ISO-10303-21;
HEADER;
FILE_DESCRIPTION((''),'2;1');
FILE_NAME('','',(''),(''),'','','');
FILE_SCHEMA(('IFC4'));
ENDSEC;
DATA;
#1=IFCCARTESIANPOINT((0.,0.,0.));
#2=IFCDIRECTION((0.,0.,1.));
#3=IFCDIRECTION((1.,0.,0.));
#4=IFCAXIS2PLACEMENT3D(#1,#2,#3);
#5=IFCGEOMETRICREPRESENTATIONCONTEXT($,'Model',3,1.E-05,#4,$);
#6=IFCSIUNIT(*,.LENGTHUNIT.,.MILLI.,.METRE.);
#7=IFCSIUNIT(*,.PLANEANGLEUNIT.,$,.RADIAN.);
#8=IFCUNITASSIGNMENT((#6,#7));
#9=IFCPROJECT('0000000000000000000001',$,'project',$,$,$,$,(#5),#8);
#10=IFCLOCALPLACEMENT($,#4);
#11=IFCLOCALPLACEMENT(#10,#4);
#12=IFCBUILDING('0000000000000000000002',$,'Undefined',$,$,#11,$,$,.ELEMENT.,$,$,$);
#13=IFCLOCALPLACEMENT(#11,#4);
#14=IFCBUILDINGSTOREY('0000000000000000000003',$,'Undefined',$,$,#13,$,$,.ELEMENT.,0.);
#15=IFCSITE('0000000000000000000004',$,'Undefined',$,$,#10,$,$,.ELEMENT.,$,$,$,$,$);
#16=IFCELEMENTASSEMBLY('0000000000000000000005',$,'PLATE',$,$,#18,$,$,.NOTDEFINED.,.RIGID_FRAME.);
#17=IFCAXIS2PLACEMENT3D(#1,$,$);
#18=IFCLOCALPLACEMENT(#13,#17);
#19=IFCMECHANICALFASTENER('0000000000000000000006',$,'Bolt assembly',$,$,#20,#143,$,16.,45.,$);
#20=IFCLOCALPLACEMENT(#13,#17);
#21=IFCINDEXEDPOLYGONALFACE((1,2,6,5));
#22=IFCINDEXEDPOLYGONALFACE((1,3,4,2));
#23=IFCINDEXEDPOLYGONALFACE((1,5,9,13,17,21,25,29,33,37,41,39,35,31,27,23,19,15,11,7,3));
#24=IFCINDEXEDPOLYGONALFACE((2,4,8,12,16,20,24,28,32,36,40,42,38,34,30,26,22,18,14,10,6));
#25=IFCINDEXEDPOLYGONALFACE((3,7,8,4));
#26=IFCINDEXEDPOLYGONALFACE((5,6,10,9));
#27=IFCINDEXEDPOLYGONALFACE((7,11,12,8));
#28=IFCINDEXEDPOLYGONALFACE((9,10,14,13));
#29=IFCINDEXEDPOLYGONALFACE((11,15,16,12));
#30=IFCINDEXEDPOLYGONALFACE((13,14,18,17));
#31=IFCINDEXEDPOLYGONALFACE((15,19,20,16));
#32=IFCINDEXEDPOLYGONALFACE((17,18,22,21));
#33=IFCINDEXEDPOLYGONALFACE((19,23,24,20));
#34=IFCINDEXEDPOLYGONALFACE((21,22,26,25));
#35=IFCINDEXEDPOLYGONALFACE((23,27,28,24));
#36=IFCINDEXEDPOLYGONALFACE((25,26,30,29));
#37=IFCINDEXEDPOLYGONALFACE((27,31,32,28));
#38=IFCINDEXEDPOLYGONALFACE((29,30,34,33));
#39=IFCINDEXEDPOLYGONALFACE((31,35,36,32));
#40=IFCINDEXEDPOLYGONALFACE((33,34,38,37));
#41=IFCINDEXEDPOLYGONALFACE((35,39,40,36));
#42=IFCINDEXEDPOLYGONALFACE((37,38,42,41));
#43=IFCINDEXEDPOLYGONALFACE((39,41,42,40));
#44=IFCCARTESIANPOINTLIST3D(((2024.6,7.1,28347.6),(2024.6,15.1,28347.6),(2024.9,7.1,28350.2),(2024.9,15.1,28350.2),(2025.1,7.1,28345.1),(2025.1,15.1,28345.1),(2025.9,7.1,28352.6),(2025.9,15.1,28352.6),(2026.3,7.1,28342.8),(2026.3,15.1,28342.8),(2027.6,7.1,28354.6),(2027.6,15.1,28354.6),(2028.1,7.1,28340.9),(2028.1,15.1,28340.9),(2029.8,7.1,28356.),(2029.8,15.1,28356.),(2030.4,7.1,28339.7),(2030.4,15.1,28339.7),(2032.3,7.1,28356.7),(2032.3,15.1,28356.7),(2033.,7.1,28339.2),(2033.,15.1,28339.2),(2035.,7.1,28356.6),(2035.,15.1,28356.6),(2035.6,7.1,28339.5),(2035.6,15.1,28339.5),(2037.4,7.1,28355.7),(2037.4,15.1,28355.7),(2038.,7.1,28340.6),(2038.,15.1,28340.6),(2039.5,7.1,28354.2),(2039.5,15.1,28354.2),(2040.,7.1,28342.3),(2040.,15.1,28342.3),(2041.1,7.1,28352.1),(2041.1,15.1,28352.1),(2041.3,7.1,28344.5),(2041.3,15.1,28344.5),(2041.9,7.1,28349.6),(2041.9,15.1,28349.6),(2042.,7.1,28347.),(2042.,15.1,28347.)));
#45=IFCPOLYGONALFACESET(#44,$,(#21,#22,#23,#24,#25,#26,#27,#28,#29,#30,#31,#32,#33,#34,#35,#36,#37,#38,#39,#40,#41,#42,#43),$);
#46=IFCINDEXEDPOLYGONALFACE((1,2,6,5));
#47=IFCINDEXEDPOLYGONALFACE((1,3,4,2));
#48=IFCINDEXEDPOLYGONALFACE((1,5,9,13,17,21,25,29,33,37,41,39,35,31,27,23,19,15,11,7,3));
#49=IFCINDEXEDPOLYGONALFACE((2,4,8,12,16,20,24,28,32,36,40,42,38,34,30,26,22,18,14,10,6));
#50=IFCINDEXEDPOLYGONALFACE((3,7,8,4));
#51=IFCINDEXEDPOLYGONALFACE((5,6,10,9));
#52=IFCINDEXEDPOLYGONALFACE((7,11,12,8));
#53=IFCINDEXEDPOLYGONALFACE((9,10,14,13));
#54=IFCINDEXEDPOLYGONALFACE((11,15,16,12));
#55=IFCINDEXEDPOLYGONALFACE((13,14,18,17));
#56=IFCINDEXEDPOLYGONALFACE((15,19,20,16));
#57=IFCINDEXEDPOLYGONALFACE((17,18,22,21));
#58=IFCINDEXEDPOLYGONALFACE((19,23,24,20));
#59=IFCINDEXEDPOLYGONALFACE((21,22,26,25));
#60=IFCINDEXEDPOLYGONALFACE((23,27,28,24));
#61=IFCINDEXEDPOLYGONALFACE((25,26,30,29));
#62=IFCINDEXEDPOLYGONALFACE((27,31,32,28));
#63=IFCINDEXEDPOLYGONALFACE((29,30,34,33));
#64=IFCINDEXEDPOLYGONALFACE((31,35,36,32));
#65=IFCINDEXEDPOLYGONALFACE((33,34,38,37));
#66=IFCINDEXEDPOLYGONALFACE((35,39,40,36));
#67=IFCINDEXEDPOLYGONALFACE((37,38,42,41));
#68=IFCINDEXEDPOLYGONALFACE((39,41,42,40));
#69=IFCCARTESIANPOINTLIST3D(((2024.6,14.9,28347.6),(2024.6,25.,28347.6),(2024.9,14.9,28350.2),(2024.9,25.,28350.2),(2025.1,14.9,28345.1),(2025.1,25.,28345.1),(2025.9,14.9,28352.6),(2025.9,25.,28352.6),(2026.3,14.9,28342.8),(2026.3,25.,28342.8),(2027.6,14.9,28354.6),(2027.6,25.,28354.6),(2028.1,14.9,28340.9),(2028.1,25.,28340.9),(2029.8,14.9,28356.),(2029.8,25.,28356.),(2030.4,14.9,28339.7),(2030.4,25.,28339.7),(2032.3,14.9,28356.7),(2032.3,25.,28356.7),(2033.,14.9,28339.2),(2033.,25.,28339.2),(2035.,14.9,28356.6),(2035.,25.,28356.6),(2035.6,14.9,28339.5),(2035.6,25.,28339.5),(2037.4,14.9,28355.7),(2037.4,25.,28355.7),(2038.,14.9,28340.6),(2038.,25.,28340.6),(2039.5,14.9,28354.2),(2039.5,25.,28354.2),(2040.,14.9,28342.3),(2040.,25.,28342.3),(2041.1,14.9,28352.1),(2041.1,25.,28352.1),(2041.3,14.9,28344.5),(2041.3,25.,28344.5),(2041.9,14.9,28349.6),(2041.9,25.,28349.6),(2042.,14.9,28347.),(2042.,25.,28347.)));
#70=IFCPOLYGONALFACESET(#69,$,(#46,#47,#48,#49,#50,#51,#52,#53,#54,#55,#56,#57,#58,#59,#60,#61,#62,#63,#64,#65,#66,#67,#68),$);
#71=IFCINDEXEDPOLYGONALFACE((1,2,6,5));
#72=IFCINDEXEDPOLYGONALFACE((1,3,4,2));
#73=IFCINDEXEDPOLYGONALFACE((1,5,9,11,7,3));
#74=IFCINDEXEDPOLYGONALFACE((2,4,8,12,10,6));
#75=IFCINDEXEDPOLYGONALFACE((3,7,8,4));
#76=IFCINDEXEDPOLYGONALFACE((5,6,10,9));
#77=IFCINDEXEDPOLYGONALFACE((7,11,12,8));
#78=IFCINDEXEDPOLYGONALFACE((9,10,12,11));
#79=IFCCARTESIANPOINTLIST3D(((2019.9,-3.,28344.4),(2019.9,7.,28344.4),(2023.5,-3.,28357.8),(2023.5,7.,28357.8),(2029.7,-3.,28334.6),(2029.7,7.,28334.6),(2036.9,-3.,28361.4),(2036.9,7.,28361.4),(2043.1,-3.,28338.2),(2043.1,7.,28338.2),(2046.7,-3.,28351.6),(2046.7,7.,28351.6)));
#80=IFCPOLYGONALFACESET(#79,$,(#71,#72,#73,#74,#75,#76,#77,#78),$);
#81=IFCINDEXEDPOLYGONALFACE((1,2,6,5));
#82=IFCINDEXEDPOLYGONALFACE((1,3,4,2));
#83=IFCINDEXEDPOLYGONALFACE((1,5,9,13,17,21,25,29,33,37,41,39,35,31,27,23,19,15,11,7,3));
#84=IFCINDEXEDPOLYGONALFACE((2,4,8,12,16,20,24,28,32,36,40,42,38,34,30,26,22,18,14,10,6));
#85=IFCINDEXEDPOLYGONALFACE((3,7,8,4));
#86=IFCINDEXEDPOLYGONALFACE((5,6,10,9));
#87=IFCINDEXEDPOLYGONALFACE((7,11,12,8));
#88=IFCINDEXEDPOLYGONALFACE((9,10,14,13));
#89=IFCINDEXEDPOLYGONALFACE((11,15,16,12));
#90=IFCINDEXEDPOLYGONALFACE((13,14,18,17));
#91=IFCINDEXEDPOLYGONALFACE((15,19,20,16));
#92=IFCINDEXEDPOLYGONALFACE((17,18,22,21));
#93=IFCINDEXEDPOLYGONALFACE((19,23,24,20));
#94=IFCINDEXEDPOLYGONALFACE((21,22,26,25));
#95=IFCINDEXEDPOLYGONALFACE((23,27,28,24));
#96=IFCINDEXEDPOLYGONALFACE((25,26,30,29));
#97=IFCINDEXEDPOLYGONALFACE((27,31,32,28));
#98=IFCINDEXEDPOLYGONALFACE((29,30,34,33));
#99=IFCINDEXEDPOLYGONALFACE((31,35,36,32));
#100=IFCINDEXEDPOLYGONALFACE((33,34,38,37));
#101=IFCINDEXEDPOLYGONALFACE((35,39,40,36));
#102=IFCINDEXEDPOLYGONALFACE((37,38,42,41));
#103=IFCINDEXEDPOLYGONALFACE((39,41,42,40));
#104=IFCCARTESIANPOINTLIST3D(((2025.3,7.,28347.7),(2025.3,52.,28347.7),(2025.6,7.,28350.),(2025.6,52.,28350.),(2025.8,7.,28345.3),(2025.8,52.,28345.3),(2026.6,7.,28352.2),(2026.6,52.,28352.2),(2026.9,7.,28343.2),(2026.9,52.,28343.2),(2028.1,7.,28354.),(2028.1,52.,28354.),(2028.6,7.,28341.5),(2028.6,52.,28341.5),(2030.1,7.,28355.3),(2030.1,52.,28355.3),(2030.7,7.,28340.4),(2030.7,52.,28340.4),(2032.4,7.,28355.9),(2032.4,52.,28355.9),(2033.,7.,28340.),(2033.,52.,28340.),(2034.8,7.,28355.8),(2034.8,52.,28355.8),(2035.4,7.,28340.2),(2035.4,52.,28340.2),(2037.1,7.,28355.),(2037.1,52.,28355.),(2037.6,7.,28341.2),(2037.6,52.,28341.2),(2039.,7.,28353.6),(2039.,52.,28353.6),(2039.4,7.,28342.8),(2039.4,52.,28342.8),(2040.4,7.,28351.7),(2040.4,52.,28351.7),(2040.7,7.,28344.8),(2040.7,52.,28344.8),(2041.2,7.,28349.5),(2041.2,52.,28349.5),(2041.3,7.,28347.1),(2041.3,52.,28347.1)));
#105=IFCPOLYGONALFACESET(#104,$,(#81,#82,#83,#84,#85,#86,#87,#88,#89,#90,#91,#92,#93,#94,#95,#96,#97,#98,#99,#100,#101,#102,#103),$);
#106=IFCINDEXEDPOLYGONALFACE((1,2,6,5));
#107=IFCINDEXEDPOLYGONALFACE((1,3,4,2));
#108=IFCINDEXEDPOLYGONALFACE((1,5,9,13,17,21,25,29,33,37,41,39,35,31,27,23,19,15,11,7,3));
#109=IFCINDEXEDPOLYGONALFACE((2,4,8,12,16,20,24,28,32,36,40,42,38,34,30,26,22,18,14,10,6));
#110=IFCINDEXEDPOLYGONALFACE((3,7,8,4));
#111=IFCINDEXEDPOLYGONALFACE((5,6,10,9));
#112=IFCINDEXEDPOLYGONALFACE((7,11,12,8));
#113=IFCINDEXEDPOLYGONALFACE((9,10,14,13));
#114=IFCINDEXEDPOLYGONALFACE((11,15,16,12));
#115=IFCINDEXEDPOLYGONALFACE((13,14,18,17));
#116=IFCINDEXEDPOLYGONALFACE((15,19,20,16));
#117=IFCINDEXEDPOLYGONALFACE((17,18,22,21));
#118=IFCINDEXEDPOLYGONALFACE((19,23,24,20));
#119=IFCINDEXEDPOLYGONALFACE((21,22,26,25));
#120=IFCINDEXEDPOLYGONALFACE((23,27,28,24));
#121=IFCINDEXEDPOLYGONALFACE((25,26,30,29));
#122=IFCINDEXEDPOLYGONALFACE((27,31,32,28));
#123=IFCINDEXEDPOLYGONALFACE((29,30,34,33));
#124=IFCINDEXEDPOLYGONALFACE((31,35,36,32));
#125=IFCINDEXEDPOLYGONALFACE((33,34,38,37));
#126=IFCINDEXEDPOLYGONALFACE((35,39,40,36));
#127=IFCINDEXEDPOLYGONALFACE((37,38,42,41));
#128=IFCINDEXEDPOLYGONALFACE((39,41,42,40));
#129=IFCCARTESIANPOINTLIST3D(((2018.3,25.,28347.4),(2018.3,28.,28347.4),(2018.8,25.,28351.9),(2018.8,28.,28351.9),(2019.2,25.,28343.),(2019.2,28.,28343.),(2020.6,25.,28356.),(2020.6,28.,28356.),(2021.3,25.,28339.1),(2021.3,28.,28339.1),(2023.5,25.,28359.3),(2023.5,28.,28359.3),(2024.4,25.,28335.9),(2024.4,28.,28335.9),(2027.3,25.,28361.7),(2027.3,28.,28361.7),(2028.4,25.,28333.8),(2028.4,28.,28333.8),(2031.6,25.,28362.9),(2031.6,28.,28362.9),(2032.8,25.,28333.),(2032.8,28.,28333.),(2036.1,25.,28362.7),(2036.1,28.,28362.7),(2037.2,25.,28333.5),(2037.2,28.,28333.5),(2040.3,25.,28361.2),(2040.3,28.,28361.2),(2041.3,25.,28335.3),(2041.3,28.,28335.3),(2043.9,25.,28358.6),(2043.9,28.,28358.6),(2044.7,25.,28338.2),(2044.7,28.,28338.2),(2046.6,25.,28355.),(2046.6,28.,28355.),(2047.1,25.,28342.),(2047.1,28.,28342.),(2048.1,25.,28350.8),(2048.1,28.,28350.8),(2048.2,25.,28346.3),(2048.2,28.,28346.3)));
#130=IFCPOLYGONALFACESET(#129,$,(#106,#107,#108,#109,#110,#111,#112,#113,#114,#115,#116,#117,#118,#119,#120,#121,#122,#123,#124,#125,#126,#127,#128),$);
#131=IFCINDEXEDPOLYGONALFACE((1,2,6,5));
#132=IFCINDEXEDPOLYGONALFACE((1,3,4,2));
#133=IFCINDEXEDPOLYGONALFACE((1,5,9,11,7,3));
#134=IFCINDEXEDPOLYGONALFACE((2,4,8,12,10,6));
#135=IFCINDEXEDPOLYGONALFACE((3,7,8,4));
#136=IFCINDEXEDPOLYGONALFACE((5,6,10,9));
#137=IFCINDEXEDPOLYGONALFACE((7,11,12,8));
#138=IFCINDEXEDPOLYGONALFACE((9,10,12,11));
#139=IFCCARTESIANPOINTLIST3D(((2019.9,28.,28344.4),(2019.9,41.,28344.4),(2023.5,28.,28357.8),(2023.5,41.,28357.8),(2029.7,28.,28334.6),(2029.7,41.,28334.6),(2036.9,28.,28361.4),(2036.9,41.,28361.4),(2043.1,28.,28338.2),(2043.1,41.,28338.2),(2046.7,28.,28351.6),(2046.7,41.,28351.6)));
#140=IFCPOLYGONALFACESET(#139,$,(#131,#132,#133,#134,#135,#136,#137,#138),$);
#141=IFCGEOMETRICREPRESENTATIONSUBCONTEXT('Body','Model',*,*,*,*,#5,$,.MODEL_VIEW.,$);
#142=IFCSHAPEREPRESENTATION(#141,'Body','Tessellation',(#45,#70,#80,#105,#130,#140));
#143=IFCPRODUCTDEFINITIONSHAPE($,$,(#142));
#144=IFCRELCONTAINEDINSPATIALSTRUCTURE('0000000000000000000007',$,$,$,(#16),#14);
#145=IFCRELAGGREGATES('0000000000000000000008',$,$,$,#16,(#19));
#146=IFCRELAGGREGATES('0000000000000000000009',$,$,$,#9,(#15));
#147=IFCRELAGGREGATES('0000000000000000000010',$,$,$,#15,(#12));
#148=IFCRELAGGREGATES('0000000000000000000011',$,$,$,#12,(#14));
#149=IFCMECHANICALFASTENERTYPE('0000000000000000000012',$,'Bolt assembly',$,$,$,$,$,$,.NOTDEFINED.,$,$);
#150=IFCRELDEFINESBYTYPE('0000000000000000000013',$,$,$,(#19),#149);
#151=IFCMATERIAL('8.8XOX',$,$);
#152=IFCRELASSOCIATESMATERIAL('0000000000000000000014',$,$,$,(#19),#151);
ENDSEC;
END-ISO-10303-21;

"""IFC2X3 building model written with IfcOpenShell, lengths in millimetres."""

from ifc_helpers import new_model, si_unit, frame, origin_with_axes, origin_2d_with_axis, place, context, subcontext, project, spatial, polyline, circle, outline, extrude, source, transform, mapped, material, type_object, element, aggregate, save


model = new_model("IFC2X3")

# Units and contexts
model_context = context("Model", 3, precision=1e-05, world=origin_with_axes())
body_context = subcontext(model_context, "Body", "Model", "MODEL_VIEW")
ifc_project = project(units=[si_unit("LENGTHUNIT", "METRE", prefix="MILLI"), si_unit("PLANEANGLEUNIT", "RADIAN")], contexts=[model_context])

# Site, building, storey
site_placement = place(None, origin_with_axes())
site = spatial("IfcSite", under=ifc_project, at=site_placement, Name="Undefined", CompositionType="ELEMENT")
building_placement = place(site_placement, origin_with_axes())
building = spatial("IfcBuilding", under=site, at=building_placement, Name="Undefined", CompositionType="ELEMENT")
storey_placement = place(building_placement, origin_with_axes())
storey = spatial("IfcBuildingStorey", under=building, at=storey_placement, Name="Undefined", CompositionType="ELEMENT", Elevation=0.0)

# Element assembly
assembly_1_placement = place(storey_placement, origin_with_axes())
assembly_1 = element("IfcElementAssembly", 1, at=assembly_1_placement, inside=storey, Name="PLATE", AssemblyPlace="NOTDEFINED", PredefinedType="RIGID_FRAME")

# Mechanical fastener
ifc_material_1 = material(Name="8.8XOX")
mechanical_fastener_type = type_object("IfcMechanicalFastenerType", Name="Bolt assembly")
shared_shape_1 = source(origin_with_axes(), body_context, "Body", "SweptSolid", [
    extrude(circle(Radius=8.8, at=origin_2d_with_axis()), frame((0.0, 7.1, 0.0), z_axis=(0.0, 1.0, 0.0), x_axis=(1.0, 0.0, 0.0)), (0.0, 0.0, 1.0), 8.0),
    extrude(circle(Radius=8.8, at=origin_2d_with_axis()), frame((0.0, 14.9, 0.0), z_axis=(0.0, 1.0, 0.0), x_axis=(1.0, 0.0, 0.0)), (0.0, 0.0, 1.0), 10.1),
    extrude(outline(polyline([(12.0, -6.9), (12.0, 6.9), (0.0, 13.9), (-12.0, 6.9), (-12.0, -6.9), (0.0, -13.9), (12.0, -6.9)])), frame((0.0, -3.0, 0.0), z_axis=(0.0, 1.0, 0.0), x_axis=(1.0, 0.0, 0.0)), (0.0, 0.0, 1.0), 10.0),
    extrude(circle(Radius=8.0, at=origin_2d_with_axis()), frame((0.0, 7.0, 0.0), z_axis=(0.0, 1.0, 0.0), x_axis=(1.0, 0.0, 0.0)), (0.0, 0.0, 1.0), 45.0),
    extrude(circle(Radius=15.0, at=origin_2d_with_axis()), frame((0.0, 25.0, 0.0), z_axis=(0.0, 1.0, 0.0), x_axis=(1.0, 0.0, 0.0)), (0.0, 0.0, 1.0), 3.0),
    extrude(outline(polyline([(12.0, -6.9), (12.0, 6.9), (0.0, 13.9), (-12.0, 6.9), (-12.0, -6.9), (0.0, -13.9), (12.0, -6.9)])), frame((0.0, 28.0, 0.0), z_axis=(0.0, 1.0, 0.0), x_axis=(1.0, 0.0, 0.0)), (0.0, 0.0, 1.0), 13.0),
])
mechanical_fastener_1_placement = place(assembly_1_placement, frame((2033.3, 0.0, 28348.0), z_axis=(-0.707107, 0.0, 0.707107), x_axis=(0.707107, 0.0, 0.707107)))
mechanical_fastener_1 = element("IfcMechanicalFastener", 2, at=mechanical_fastener_1_placement, type_object=mechanical_fastener_type, material=ifc_material_1, Name="Bolt assembly", NominalDiameter=16.0, NominalLength=45.0, context=body_context, shape_type="MappedRepresentation", body=[
    mapped(shared_shape_1, transform((0.0, 0.0, 0.0))),
])
aggregate(assembly_1, [mechanical_fastener_1])

save(model, "model.ifc")
